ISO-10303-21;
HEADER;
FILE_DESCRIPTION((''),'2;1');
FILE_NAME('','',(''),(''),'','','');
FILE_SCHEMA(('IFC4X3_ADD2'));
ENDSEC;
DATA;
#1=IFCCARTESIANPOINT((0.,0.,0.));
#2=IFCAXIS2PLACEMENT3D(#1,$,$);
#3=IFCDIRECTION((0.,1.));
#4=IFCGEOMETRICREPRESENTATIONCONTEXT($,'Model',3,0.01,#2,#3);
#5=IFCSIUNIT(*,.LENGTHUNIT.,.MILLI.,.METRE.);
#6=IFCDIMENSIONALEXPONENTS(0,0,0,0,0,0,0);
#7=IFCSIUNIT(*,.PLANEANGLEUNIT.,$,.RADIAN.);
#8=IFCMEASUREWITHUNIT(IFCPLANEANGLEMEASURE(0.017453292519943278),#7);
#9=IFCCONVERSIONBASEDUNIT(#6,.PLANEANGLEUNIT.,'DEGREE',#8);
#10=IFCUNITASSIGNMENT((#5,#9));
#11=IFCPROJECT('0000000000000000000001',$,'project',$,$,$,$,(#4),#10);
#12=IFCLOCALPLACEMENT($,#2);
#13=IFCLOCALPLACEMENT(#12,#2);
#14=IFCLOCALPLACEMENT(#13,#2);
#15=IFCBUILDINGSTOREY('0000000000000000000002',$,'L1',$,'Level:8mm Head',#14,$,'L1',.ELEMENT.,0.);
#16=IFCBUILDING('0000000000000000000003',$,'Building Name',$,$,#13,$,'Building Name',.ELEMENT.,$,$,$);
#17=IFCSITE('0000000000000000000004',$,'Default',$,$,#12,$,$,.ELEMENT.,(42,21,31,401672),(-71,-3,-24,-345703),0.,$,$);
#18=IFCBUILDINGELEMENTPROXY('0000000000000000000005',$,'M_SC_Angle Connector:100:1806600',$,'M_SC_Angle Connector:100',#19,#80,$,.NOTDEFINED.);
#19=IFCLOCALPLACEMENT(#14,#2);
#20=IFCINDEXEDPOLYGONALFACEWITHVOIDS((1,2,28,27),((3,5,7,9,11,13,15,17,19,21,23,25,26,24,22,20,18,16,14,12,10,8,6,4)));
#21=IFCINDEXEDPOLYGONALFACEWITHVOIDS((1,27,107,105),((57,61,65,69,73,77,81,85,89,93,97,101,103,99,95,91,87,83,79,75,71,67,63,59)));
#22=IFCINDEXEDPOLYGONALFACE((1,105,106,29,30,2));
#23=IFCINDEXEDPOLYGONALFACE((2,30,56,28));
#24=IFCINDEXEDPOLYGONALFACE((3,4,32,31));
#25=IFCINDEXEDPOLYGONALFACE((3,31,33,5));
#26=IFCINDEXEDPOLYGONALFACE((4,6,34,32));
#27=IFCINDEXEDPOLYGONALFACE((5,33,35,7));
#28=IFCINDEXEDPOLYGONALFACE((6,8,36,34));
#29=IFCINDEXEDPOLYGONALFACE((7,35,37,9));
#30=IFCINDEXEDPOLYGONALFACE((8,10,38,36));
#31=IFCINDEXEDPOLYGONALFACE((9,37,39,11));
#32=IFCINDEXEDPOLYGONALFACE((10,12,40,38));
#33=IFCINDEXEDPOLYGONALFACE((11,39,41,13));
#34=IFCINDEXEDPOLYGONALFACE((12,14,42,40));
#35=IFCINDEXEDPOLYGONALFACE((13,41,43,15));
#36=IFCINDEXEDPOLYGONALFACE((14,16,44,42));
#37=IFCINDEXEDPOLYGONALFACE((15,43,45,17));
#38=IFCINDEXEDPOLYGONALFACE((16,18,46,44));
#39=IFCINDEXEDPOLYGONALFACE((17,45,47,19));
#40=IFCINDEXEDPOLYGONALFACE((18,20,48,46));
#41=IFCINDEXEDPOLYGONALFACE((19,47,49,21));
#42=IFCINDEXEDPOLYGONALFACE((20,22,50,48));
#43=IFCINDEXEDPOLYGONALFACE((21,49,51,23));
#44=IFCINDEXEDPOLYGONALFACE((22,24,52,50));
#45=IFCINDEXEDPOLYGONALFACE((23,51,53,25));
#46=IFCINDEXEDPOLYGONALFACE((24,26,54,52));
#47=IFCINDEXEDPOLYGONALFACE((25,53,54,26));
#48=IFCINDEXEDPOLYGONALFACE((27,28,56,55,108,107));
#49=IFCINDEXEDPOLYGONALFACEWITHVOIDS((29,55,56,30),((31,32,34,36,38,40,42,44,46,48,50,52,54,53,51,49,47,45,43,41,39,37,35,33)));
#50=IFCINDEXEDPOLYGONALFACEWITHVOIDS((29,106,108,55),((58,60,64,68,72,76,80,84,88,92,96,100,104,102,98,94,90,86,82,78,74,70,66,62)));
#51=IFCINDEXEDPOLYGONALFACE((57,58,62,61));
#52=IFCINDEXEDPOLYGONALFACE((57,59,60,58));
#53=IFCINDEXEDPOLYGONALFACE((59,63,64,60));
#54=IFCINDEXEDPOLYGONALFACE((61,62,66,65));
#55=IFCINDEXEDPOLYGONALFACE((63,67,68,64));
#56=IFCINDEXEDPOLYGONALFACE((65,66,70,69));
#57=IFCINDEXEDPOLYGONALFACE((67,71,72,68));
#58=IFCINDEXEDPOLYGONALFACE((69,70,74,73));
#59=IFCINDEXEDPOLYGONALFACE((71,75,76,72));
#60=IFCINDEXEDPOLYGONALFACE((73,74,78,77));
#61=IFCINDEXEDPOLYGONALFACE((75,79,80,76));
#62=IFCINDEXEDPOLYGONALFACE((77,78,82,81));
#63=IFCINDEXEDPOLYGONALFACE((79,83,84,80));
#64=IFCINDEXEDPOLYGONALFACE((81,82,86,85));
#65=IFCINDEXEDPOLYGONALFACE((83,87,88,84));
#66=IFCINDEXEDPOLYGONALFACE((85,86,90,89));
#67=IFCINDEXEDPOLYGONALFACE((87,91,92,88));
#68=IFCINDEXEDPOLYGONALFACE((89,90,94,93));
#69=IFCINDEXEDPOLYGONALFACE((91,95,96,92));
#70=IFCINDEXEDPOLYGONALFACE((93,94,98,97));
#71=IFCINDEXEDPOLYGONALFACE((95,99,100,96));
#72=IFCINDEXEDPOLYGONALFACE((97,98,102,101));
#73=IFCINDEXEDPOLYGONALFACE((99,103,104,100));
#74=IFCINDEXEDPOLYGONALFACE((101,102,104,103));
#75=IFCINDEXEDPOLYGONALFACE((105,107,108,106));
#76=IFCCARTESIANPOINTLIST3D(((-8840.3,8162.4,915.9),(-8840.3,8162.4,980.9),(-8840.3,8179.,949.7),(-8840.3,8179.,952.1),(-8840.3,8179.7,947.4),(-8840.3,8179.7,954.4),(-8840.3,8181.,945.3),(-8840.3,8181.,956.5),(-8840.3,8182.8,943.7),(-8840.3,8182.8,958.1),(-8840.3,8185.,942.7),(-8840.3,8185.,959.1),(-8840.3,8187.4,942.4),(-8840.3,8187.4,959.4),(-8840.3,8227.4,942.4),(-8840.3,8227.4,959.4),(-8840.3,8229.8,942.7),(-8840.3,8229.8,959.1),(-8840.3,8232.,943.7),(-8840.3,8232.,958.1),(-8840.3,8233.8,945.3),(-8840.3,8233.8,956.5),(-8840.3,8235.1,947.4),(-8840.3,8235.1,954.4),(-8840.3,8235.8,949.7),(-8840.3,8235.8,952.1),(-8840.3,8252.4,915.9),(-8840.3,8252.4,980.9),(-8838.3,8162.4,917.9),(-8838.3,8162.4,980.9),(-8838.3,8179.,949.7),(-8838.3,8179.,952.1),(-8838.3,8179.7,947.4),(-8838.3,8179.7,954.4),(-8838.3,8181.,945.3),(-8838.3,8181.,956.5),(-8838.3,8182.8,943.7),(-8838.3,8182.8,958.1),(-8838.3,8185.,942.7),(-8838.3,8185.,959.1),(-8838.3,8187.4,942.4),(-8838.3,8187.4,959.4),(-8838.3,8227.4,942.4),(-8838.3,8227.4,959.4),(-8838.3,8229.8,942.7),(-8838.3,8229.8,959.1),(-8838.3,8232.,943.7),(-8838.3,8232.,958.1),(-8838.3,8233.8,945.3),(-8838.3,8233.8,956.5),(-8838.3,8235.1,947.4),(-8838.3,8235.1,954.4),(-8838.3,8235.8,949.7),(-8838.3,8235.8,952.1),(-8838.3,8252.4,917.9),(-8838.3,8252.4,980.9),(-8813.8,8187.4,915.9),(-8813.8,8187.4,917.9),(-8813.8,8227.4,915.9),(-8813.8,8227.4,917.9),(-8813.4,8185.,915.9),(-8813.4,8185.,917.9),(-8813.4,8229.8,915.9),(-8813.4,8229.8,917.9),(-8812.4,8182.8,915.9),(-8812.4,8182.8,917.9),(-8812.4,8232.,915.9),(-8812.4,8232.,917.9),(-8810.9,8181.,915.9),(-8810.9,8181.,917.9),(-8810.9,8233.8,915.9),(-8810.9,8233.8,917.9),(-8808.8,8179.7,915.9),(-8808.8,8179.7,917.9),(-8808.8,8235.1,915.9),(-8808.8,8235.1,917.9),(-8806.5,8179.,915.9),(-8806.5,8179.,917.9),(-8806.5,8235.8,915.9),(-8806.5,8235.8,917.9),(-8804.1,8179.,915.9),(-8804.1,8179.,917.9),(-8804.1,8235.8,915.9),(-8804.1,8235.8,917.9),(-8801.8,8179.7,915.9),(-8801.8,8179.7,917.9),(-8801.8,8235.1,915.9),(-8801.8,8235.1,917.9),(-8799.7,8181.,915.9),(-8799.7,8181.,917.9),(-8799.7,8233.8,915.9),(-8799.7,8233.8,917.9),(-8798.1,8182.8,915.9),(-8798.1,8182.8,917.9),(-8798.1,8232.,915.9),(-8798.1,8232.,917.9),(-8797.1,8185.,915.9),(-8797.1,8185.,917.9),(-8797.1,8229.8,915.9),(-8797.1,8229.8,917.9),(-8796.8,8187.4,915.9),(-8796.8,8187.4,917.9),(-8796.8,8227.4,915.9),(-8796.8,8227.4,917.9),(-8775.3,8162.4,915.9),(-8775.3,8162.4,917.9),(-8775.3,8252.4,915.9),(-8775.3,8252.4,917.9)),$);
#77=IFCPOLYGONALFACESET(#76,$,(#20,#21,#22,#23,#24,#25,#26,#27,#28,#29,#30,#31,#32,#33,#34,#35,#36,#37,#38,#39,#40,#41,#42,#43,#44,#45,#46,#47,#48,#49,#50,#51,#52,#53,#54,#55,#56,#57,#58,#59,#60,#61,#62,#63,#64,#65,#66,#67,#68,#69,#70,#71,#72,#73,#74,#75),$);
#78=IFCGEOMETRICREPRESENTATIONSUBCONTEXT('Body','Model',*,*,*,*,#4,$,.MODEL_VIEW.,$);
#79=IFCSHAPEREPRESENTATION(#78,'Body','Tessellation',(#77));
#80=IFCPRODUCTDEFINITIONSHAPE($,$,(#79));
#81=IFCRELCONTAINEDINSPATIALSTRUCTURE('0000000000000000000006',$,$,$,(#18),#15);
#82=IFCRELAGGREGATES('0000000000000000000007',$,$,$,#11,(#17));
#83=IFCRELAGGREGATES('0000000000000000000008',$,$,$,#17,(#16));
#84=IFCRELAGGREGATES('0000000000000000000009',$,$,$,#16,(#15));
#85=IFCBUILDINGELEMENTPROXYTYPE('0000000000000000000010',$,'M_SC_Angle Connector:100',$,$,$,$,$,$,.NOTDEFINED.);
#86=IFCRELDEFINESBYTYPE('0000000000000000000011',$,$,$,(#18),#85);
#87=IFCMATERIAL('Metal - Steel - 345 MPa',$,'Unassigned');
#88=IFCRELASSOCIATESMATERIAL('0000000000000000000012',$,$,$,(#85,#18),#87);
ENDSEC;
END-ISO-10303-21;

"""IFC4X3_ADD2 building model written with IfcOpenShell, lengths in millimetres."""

from ifc_helpers import new_model, entity, si_unit, converted_unit, direction, frame, frame_2d, origin, place, context, subcontext, project, spatial, polyline, circle_curve, parameter, trimmed, segment, composite_curve, outline, extrude, source, transform, mapped, material, type_object, type_shapes, element, save


model = new_model("IFC4X3_ADD2")

# Units and contexts
model_context = context("Model", 3, precision=0.01, world=origin(), true_north=direction((0.0, 1.0)))
body_context = subcontext(model_context, "Body", "Model", "MODEL_VIEW")
ifc_project = project(units=[si_unit("LENGTHUNIT", "METRE", prefix="MILLI"), converted_unit("PLANEANGLEUNIT", "DEGREE", entity("IfcPlaneAngleMeasure", 0.017453292519943278), si_unit("PLANEANGLEUNIT", "RADIAN"), dimensions=[0, 0, 0, 0, 0, 0, 0])], contexts=[model_context])

# Site, building, storey
site_placement = place(None, origin())
site = spatial("IfcSite", under=ifc_project, at=site_placement, Name="Default", CompositionType="ELEMENT", RefLatitude=(42, 21, 31, 401672), RefLongitude=(-71, -3, -24, -345703), RefElevation=0.0)
building_placement = place(site_placement, origin())
building = spatial("IfcBuilding", under=site, at=building_placement, Name="Building Name", LongName="Building Name", CompositionType="ELEMENT")
storey_placement = place(building_placement, origin())
storey = spatial("IfcBuildingStorey", under=building, at=storey_placement, Name="L1", ObjectType="Level:8mm Head", LongName="L1", CompositionType="ELEMENT", Elevation=0.0)

# Building element proxy, openings
ifc_material_1 = material(Name="Metal - Steel - 345 MPa", Category="Unassigned")
building_element_proxy_type_1 = type_object("IfcBuildingElementProxyType", Name="M_SC_Angle Connector:100", PredefinedType="NOTDEFINED", material=ifc_material_1)
shared_shape_1 = source(origin(), body_context, "Body", "SweptSolid", [
    extrude(outline(polyline([(-22.3, -42.7), (-20.3, -42.7), (-20.3, 20.3), (42.7, 20.3), (42.7, 22.3), (-22.3, 22.3), (-22.3, -42.7)])), frame((-22.3, -45.0, 22.3), z_axis=(0.0, 1.0, 0.0), x_axis=(0.0, 0.0, 1.0)), (0.0, 0.0, 1.0), 90.0),
])
type_shapes(building_element_proxy_type_1, [shared_shape_1])
proxy_1_placement = place(storey_placement, frame((-8840.3, 8207.4, 915.9), z_axis=(0.0, 0.0, 1.0), x_axis=(-1.0, 0.0, 0.0)))
proxy_1 = element("IfcBuildingElementProxy", 1, at=proxy_1_placement, inside=storey, type_object=building_element_proxy_type_1, material=ifc_material_1, Name="M_SC_Angle Connector:100:1806600", ObjectType="M_SC_Angle Connector:100", PredefinedType="NOTDEFINED", context=body_context, shape_type="MappedRepresentation", body=[
    mapped(shared_shape_1, transform((0.0, 0.0, 0.0), scale=1.0)),
])
opening_1_placement = place(storey_placement, frame((-8840.3, 8207.4, 915.9)))
element("IfcOpeningElement", 2, at=opening_1_placement, cuts=proxy_1, PredefinedType="OPENING", context=body_context, shape_type="SweptSolid", body=[
    extrude(outline(composite_curve([segment(polyline([(-20.0, -8.5), (20.0, -8.5)]), True, "CONTINUOUS"), segment(trimmed(circle_curve(frame_2d((20.0, 0.0), x_axis=(0.0, -1.0)), 8.5), [parameter(0.0)], [parameter(180.0)], True, "PARAMETER"), True, "CONTINUOUS"), segment(polyline([(20.0, 8.5), (-20.0, 8.5)]), True, "CONTINUOUS"), segment(trimmed(circle_curve(frame_2d((-20.0, 0.0), x_axis=(0.0, -1.0)), 8.5), [parameter(180.0)], [parameter(0.0)], True, "PARAMETER"), True, "CONTINUOUS")], self_intersect=False)), frame((2.0, 0.0, 35.0), z_axis=(-1.0, 0.0, 0.0), x_axis=(0.0, 1.0, 0.0)), (0.0, 0.0, 1.0), 2.0),
])
opening_2_placement = place(storey_placement, frame((-8840.3, 8207.4, 915.9)))
element("IfcOpeningElement", 3, at=opening_2_placement, cuts=proxy_1, PredefinedType="OPENING", context=body_context, shape_type="SweptSolid", body=[
    extrude(outline(composite_curve([segment(polyline([(-20.0, -8.5), (20.0, -8.5)]), True, "CONTINUOUS"), segment(trimmed(circle_curve(frame_2d((20.0, 0.0), x_axis=(0.0, -1.0)), 8.5), [parameter(360.0)], [parameter(180.0)], True, "PARAMETER"), True, "CONTINUOUS"), segment(polyline([(20.0, 8.5), (-20.0, 8.5)]), True, "CONTINUOUS"), segment(trimmed(circle_curve(frame_2d((-20.0, 0.0), x_axis=(0.0, -1.0)), 8.5), [parameter(180.0)], [parameter(360.0)], True, "PARAMETER"), True, "CONTINUOUS")], self_intersect=False)), frame((35.0, 0.0, 2.0), z_axis=(0.0, 0.0, -1.0), x_axis=(0.0, 1.0, 0.0)), (0.0, 0.0, 1.0), 2.0),
])

save(model, "model.ifc")
